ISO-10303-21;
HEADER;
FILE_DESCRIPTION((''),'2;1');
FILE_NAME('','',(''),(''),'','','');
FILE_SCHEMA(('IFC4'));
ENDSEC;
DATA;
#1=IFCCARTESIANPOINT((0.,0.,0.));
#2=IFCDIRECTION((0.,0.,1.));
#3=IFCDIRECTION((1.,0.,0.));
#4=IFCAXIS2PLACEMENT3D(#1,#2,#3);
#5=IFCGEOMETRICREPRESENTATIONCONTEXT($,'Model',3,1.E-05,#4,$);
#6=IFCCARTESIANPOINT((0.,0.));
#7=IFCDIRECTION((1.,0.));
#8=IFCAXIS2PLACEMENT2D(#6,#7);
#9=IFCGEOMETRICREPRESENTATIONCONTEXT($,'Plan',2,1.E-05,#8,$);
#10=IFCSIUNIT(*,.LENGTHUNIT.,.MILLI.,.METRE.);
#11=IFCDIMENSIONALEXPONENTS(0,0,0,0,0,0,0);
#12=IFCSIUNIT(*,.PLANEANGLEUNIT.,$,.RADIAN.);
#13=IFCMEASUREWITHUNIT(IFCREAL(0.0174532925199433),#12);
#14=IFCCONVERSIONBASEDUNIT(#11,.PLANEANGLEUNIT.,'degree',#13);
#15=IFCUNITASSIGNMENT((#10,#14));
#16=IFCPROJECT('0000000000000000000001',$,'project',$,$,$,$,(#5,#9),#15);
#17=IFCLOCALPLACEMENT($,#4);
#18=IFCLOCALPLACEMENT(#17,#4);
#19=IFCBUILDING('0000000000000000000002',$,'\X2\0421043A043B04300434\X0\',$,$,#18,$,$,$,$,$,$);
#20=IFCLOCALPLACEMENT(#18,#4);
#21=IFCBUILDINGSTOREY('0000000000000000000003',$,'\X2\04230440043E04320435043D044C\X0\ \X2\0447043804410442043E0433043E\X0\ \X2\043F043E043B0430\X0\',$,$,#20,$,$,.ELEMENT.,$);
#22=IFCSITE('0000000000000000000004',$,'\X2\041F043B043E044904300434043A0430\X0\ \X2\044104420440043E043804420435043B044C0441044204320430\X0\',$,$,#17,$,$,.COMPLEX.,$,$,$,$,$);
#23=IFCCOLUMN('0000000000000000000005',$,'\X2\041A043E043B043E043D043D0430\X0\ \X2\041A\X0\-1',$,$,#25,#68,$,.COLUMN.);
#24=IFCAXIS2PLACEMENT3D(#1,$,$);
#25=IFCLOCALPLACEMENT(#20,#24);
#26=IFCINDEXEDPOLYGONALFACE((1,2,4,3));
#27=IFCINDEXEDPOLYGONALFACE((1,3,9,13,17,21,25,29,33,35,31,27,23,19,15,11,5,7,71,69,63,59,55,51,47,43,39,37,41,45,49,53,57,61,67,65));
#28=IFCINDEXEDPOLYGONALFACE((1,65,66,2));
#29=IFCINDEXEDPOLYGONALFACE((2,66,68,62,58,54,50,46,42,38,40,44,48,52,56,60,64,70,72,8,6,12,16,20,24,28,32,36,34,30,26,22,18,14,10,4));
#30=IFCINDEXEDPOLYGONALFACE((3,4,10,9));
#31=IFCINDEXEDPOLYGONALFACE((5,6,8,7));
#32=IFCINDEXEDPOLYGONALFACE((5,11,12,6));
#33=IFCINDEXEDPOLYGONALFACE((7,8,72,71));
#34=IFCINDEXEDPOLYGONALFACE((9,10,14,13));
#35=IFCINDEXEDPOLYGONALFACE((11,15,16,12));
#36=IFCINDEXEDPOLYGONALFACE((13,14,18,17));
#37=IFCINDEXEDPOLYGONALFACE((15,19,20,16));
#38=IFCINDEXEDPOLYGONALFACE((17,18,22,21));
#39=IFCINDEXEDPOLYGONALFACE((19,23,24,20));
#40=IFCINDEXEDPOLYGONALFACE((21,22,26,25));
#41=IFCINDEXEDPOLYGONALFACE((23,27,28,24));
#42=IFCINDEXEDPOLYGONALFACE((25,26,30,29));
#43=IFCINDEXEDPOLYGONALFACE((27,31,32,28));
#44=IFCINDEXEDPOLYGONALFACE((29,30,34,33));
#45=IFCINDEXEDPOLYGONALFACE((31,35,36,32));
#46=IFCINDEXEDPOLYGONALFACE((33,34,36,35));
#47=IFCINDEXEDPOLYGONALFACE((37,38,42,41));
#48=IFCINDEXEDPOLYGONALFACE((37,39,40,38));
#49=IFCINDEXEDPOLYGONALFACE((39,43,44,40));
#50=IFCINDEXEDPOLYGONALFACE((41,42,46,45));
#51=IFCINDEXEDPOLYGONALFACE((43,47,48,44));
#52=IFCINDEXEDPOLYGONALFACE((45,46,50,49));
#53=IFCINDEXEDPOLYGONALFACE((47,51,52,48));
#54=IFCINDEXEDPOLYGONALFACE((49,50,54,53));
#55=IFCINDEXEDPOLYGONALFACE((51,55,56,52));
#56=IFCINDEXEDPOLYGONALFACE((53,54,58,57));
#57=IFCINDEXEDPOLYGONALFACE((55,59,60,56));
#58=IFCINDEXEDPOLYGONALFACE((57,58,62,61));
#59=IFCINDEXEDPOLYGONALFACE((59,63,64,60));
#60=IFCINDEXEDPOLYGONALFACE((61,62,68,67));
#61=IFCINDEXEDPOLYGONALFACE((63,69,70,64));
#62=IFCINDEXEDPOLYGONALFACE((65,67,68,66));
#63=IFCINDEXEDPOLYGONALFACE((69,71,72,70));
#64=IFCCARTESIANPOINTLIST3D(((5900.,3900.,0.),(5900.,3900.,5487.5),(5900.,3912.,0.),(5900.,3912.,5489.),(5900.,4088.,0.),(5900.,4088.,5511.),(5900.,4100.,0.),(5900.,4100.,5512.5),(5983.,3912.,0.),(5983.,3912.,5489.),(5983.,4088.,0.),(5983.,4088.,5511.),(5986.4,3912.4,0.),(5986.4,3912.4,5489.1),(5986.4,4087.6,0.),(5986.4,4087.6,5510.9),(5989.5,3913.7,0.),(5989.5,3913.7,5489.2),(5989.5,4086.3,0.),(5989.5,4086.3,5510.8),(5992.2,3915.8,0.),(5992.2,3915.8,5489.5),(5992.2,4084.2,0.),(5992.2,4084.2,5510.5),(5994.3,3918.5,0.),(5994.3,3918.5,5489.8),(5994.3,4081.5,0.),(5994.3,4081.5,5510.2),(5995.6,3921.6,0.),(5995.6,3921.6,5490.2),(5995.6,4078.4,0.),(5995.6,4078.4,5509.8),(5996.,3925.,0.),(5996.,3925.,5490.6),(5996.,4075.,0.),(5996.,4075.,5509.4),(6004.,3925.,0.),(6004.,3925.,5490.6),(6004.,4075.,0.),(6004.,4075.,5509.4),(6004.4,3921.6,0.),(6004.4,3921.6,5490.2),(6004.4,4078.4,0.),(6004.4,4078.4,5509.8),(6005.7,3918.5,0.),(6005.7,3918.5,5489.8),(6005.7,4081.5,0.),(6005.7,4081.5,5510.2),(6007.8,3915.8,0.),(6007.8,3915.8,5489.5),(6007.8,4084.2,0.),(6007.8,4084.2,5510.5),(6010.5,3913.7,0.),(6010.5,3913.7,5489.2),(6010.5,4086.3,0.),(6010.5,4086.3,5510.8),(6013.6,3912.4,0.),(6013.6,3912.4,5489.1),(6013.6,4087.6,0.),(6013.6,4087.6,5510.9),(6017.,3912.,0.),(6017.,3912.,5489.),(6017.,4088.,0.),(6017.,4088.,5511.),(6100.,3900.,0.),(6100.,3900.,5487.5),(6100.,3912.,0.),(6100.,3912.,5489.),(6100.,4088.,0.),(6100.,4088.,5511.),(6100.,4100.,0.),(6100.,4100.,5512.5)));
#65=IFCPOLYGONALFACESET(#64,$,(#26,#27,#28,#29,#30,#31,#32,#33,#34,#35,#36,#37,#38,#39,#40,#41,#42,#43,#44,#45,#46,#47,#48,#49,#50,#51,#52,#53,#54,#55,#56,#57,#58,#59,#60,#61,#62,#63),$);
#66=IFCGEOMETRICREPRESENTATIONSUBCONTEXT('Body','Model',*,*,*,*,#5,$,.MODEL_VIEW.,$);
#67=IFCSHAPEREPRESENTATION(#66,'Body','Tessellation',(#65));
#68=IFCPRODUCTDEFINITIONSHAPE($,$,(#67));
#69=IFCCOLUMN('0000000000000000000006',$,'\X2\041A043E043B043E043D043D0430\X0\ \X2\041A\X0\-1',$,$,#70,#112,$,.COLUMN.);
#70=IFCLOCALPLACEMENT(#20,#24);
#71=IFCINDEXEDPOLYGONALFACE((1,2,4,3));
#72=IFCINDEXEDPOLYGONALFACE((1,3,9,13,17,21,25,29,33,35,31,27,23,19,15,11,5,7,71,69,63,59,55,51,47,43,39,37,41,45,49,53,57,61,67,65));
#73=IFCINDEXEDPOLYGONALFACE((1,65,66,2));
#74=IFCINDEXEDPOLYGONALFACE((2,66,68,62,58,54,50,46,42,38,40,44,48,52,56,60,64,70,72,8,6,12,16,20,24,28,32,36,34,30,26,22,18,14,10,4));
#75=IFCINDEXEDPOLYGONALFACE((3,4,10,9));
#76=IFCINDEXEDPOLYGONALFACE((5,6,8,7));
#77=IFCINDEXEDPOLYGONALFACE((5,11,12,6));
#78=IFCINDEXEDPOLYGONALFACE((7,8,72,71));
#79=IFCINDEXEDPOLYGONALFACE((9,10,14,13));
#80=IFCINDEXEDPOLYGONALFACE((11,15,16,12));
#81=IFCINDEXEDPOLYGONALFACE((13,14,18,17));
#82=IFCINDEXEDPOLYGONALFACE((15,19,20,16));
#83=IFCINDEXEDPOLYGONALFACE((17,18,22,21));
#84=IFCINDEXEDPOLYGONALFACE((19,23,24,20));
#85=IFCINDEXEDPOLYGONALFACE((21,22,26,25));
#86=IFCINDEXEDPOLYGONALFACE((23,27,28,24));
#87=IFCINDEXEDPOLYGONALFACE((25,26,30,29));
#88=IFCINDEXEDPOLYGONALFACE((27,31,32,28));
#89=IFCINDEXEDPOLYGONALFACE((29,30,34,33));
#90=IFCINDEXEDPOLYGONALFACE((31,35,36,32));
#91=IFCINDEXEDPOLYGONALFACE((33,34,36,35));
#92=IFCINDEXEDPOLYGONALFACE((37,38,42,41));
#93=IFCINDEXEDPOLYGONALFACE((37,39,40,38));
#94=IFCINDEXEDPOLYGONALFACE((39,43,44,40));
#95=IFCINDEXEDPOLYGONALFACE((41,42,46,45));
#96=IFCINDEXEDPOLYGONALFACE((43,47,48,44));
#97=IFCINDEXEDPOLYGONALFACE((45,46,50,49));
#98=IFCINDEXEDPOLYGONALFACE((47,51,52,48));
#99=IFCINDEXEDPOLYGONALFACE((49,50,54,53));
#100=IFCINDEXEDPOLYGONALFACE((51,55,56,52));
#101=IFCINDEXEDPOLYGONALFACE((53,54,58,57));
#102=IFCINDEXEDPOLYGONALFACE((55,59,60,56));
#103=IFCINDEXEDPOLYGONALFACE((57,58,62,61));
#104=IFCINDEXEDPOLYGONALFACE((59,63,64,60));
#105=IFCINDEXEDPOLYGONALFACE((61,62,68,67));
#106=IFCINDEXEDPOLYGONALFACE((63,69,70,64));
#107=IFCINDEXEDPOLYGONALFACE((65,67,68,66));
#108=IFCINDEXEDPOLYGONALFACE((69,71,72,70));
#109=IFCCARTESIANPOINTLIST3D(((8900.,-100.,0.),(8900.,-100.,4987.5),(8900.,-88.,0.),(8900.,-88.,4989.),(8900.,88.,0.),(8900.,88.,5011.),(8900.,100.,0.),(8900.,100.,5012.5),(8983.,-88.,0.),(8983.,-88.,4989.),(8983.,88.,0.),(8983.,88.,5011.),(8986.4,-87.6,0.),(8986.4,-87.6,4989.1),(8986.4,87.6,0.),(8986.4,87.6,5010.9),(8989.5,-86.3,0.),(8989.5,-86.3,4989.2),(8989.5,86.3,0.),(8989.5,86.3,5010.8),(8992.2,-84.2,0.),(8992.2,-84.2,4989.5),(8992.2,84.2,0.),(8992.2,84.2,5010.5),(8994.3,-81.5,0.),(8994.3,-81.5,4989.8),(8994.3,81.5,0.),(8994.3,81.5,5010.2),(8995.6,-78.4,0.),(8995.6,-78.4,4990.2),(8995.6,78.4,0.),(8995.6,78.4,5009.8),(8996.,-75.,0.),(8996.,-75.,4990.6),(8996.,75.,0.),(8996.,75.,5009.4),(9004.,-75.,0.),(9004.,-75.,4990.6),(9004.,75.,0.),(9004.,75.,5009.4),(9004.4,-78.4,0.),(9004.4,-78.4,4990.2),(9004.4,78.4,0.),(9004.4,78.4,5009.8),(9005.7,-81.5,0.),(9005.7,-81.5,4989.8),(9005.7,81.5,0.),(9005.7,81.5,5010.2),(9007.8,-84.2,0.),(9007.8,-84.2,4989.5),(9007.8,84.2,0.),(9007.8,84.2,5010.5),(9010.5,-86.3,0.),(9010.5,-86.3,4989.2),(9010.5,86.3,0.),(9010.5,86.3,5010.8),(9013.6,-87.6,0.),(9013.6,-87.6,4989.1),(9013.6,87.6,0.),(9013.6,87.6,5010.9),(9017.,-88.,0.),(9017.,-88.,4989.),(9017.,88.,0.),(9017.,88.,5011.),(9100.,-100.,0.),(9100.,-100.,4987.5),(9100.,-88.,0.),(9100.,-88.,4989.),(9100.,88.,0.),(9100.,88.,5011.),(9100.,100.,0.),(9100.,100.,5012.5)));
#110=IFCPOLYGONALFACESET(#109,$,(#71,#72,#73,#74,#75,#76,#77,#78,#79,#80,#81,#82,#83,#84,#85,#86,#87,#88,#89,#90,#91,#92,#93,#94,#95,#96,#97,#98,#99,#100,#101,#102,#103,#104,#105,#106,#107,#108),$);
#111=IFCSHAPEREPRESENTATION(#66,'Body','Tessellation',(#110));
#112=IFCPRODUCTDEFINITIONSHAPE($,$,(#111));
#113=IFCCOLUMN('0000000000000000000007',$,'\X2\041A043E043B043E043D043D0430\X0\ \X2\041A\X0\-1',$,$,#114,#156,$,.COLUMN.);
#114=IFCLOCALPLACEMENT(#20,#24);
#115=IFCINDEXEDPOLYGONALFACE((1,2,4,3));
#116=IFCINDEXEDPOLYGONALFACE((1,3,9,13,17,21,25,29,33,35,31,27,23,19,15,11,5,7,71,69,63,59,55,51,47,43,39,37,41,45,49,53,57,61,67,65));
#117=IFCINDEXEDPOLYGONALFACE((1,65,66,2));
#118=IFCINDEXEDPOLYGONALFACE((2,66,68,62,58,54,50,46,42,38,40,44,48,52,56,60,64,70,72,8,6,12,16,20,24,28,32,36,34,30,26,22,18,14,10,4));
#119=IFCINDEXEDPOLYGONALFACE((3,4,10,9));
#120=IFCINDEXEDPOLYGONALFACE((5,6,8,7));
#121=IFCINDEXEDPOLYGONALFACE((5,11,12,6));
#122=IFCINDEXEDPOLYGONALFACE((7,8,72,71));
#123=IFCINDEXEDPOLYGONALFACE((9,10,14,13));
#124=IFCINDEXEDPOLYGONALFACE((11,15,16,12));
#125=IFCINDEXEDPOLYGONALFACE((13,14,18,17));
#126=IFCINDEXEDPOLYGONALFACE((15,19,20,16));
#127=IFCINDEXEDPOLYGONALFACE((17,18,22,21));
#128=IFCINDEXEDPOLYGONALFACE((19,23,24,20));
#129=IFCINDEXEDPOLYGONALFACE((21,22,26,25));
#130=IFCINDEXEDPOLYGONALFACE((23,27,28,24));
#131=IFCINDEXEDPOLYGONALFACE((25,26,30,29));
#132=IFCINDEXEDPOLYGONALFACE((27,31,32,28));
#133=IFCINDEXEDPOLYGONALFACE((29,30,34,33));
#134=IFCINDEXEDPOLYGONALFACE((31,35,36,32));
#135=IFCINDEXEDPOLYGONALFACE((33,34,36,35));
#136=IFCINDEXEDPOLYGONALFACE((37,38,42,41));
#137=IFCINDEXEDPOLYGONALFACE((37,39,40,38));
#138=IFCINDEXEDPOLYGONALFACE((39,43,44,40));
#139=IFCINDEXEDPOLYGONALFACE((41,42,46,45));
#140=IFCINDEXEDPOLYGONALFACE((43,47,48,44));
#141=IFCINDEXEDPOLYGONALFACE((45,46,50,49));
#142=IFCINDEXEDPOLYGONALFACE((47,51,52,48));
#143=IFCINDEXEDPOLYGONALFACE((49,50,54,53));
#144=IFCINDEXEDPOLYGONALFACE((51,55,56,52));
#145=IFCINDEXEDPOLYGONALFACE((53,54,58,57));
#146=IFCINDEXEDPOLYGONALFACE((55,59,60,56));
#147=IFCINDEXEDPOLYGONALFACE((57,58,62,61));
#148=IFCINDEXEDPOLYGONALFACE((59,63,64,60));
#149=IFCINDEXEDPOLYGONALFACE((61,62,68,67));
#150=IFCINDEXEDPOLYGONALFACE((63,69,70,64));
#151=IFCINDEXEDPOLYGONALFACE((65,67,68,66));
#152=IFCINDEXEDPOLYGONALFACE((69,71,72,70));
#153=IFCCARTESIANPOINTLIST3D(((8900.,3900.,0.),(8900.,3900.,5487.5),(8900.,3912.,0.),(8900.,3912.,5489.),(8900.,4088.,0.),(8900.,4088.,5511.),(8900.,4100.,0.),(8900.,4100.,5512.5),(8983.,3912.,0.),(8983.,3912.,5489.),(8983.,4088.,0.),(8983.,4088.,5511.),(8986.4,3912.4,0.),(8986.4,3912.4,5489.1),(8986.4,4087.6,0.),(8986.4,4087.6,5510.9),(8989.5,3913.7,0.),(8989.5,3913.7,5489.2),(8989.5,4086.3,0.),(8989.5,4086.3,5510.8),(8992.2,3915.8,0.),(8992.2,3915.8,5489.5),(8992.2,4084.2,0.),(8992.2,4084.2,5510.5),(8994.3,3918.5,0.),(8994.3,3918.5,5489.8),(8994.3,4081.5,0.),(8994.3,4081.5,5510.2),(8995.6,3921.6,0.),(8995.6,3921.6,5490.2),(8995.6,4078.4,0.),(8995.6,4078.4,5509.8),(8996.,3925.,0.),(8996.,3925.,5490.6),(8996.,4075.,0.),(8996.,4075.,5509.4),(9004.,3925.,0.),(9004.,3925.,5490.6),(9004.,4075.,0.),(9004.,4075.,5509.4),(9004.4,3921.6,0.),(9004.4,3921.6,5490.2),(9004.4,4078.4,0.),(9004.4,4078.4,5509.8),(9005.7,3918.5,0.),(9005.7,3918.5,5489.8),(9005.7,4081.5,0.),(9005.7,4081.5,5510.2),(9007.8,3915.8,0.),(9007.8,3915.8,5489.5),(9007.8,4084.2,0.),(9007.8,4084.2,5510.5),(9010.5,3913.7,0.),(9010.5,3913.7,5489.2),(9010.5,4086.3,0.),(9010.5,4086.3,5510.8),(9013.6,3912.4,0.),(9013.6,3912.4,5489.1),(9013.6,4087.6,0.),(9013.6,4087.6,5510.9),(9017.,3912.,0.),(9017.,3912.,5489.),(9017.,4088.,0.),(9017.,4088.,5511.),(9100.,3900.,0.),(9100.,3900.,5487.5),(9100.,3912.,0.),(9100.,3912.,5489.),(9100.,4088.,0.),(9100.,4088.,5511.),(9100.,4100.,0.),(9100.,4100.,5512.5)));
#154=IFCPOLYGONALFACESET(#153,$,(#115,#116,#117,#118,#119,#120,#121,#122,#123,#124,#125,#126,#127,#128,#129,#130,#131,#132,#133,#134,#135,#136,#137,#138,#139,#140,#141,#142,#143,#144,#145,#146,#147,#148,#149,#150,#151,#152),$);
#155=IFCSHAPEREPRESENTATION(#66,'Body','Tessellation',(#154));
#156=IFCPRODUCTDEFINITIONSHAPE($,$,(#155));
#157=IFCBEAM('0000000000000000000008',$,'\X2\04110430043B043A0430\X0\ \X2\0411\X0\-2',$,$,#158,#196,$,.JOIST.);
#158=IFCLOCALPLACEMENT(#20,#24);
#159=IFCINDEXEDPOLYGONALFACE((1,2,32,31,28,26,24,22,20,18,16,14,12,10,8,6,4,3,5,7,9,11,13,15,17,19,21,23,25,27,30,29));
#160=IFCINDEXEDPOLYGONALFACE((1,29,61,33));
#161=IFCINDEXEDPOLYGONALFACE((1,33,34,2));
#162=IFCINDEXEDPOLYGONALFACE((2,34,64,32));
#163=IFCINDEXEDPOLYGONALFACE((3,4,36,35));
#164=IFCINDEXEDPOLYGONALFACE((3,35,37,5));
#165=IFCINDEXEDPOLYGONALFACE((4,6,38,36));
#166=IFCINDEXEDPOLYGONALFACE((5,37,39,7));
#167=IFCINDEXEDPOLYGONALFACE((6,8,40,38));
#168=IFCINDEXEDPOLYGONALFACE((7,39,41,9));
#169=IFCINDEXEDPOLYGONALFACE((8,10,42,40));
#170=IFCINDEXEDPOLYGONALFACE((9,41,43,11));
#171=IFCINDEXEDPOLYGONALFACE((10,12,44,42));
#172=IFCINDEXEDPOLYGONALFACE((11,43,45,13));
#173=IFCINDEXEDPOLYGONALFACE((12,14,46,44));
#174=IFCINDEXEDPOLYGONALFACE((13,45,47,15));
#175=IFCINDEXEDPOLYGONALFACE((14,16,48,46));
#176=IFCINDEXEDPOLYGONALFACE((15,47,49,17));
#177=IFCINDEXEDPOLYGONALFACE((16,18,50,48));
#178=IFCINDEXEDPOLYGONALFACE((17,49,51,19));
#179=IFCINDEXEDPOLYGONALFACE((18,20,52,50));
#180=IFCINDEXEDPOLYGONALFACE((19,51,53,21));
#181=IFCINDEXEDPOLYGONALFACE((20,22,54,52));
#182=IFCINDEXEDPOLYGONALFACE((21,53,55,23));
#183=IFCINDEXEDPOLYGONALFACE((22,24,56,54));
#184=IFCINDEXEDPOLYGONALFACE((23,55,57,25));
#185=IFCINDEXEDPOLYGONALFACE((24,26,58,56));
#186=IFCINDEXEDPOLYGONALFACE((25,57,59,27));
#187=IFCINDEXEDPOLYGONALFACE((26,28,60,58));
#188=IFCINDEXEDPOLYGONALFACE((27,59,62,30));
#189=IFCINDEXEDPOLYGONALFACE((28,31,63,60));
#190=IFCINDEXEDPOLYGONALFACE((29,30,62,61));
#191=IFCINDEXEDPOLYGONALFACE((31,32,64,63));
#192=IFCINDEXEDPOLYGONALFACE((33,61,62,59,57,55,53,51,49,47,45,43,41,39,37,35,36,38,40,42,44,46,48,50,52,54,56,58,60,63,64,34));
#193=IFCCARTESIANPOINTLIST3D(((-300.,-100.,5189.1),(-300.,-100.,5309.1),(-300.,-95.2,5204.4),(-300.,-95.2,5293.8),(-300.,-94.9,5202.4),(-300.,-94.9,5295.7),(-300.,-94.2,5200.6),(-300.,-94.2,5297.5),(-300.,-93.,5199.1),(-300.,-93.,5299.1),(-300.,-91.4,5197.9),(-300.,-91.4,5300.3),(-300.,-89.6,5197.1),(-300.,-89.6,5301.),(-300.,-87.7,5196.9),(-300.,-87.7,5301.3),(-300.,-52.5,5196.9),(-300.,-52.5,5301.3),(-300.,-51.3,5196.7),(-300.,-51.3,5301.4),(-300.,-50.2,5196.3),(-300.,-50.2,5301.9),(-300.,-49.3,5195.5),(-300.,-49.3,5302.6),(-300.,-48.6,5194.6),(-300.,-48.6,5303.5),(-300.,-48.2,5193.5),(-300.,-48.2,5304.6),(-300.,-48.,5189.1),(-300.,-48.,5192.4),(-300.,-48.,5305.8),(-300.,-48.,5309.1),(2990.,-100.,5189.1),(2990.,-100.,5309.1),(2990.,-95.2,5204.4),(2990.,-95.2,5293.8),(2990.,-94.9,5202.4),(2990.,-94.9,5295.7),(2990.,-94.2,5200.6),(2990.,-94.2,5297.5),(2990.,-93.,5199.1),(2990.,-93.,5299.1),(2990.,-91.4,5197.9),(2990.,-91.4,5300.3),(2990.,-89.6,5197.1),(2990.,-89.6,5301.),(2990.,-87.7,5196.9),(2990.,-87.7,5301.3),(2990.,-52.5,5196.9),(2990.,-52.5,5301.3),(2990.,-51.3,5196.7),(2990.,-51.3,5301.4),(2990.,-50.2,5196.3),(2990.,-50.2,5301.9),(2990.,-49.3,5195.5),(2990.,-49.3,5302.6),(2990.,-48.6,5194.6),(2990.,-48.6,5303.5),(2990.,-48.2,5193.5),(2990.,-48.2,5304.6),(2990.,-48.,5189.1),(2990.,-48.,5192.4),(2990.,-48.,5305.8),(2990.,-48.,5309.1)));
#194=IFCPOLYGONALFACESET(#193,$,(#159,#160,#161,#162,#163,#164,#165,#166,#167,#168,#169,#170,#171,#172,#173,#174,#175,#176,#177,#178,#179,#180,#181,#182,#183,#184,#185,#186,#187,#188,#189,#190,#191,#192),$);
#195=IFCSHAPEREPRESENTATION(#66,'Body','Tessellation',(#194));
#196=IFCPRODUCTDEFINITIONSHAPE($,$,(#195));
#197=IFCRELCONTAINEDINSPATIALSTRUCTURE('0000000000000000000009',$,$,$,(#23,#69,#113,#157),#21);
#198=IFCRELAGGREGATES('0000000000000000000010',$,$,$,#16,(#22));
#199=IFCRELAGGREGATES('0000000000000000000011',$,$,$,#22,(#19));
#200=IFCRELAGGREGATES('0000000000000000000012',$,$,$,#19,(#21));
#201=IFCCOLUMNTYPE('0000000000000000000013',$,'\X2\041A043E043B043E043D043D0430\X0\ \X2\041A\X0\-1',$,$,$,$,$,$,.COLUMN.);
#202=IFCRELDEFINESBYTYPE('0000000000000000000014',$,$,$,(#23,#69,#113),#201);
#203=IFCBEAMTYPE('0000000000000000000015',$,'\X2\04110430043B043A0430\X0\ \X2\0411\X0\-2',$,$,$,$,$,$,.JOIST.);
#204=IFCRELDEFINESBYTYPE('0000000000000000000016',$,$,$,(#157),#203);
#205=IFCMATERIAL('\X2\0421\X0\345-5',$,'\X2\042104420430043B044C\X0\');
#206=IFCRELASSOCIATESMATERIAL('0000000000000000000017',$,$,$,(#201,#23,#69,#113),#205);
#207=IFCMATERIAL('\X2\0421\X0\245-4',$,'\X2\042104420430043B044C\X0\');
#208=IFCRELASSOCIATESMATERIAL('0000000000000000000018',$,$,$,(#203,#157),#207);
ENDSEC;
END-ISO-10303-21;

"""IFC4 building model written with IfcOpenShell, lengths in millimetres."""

from ifc_helpers import new_model, entity, si_unit, converted_unit, frame, origin_with_axes, origin_2d_with_axis, place, context, subcontext, project, spatial, i_section, u_section, extrude, clip, halfspace, material, material_profile, profile_set, profile_usage, type_object, element, save


model = new_model("IFC4")

# Units and contexts
model_context = context("Model", 3, precision=1e-05, world=origin_with_axes())
plan_context = context("Plan", 2, precision=1e-05, world=origin_2d_with_axis())
body_context = subcontext(model_context, "Body", "Model", "MODEL_VIEW")
ifc_project = project(units=[si_unit("LENGTHUNIT", "METRE", prefix="MILLI"), converted_unit("PLANEANGLEUNIT", "degree", entity("IfcReal", 0.0174532925199433), si_unit("PLANEANGLEUNIT", "RADIAN"), dimensions=[0, 0, 0, 0, 0, 0, 0])], contexts=[model_context, plan_context])

# Site, building, storey
site_placement = place(None, origin_with_axes())
site = spatial("IfcSite", under=ifc_project, at=site_placement, Name="Площадка строительства", CompositionType="COMPLEX")
building_placement = place(site_placement, origin_with_axes())
building = spatial("IfcBuilding", under=site, at=building_placement, Name="Склад")
storey_placement = place(building_placement, origin_with_axes())
storey = spatial("IfcBuildingStorey", under=building, at=storey_placement, Name="Уровень чистого пола", CompositionType="ELEMENT")

# Columns
ifc_material_1 = material(Name="С345-5", Category="Сталь")
ifc_material_profile_1 = material_profile(ifc_material_1, i_section(OverallWidth=200.0, OverallDepth=200.0, WebThickness=8.0, FlangeThickness=12.0, FilletRadius=13.0, FlangeEdgeRadius=0.0, FlangeSlope=0.0))
ifc_profile_set_1 = profile_set([ifc_material_profile_1], Name="I20K2_S345-5")
column_type = type_object("IfcColumnType", Name="Колонна К-1", PredefinedType="COLUMN", material=ifc_profile_set_1)
ifc_profile_usage_1 = profile_usage(ifc_profile_set_1, cardinal=5)
column_1_placement = place(storey_placement, frame((6000.0, 4000.0, 0.0), z_axis=(0.0, 0.0, 1.0), x_axis=(1.0, 0.0, 0.0)))
element("IfcColumn", 1, at=column_1_placement, inside=storey, type_object=column_type, material=ifc_profile_usage_1, Name="Колонна К-1", PredefinedType="COLUMN", context=body_context, shape_type="Clipping", body=[
    clip(extrude(i_section(OverallWidth=200.0, OverallDepth=200.0, WebThickness=8.0, FlangeThickness=12.0, FilletRadius=13.0, FlangeEdgeRadius=0.0, FlangeSlope=0.0), origin_with_axes(), (0.0, 0.0, 1.0), 5700.0), halfspace(frame((0.0, -4298.5, 4962.7), z_axis=(0.0, -0.124035, 0.992278), x_axis=(0.0, 0.992278, 0.124035)), False)),
])
ifc_profile_usage_2 = profile_usage(ifc_profile_set_1, cardinal=5)
column_2_placement = place(storey_placement, frame((9000.0, 0.0, 0.0), z_axis=(0.0, 0.0, 1.0), x_axis=(1.0, 0.0, 0.0)))
element("IfcColumn", 2, at=column_2_placement, inside=storey, type_object=column_type, material=ifc_profile_usage_2, Name="Колонна К-1", PredefinedType="COLUMN", context=body_context, shape_type="Clipping", body=[
    clip(extrude(i_section(OverallWidth=200.0, OverallDepth=200.0, WebThickness=8.0, FlangeThickness=12.0, FilletRadius=13.0, FlangeEdgeRadius=0.0, FlangeSlope=0.0), origin_with_axes(), (0.0, 0.0, 1.0), 5200.0), halfspace(frame((0.0, -298.5, 4962.7), z_axis=(0.0, -0.124035, 0.992278), x_axis=(0.0, 0.992278, 0.124035)), False)),
])
ifc_profile_usage_3 = profile_usage(ifc_profile_set_1, cardinal=5)
column_3_placement = place(storey_placement, frame((9000.0, 4000.0, 0.0), z_axis=(0.0, 0.0, 1.0), x_axis=(1.0, 0.0, 0.0)))
element("IfcColumn", 3, at=column_3_placement, inside=storey, type_object=column_type, material=ifc_profile_usage_3, Name="Колонна К-1", PredefinedType="COLUMN", context=body_context, shape_type="Clipping", body=[
    clip(extrude(i_section(OverallWidth=200.0, OverallDepth=200.0, WebThickness=8.0, FlangeThickness=12.0, FilletRadius=13.0, FlangeEdgeRadius=0.0, FlangeSlope=0.0), origin_with_axes(), (0.0, 0.0, 1.0), 5700.0), halfspace(frame((0.0, -4298.5, 4962.7), z_axis=(0.0, -0.124035, 0.992278), x_axis=(0.0, 0.992278, 0.124035)), False)),
])

# Beam
ifc_material_2 = material(Name="С245-4", Category="Сталь")
ifc_material_profile_2 = material_profile(ifc_material_2, u_section(Depth=120.0, FlangeWidth=52.0, WebThickness=4.8, FlangeThickness=7.8, FilletRadius=7.5, EdgeRadius=4.5, FlangeSlope=0.0))
ifc_profile_set_2 = profile_set([ifc_material_profile_2], Name="U12P_S245-4")
ifc_profile_usage_4 = profile_usage(ifc_profile_set_2, cardinal=3)
beam_type_1 = type_object("IfcBeamType", Name="Балка Б-2", PredefinedType="JOIST", material=ifc_profile_set_2)
beam_1_placement = place(storey_placement, frame((-300.0, -100.0, 5189.1), z_axis=(1.0, 0.0, 0.0), x_axis=(0.0, 1.0, 0.0)))
element("IfcBeam", 4, at=beam_1_placement, inside=storey, type_object=beam_type_1, material=ifc_profile_usage_4, Name="Балка Б-2", PredefinedType="JOIST", context=body_context, shape_type="SweptSolid", body=[
    extrude(u_section(Depth=120.0, FlangeWidth=52.0, WebThickness=4.8, FlangeThickness=7.8, FilletRadius=7.5, EdgeRadius=4.5, FlangeSlope=0.0), frame((26.0, 60.0, 0.0), z_axis=(0.0, 0.0, 1.0), x_axis=(1.0, 0.0, 0.0)), (0.0, 0.0, 1.0), 3290.0),
])

save(model, "model.ifc")
